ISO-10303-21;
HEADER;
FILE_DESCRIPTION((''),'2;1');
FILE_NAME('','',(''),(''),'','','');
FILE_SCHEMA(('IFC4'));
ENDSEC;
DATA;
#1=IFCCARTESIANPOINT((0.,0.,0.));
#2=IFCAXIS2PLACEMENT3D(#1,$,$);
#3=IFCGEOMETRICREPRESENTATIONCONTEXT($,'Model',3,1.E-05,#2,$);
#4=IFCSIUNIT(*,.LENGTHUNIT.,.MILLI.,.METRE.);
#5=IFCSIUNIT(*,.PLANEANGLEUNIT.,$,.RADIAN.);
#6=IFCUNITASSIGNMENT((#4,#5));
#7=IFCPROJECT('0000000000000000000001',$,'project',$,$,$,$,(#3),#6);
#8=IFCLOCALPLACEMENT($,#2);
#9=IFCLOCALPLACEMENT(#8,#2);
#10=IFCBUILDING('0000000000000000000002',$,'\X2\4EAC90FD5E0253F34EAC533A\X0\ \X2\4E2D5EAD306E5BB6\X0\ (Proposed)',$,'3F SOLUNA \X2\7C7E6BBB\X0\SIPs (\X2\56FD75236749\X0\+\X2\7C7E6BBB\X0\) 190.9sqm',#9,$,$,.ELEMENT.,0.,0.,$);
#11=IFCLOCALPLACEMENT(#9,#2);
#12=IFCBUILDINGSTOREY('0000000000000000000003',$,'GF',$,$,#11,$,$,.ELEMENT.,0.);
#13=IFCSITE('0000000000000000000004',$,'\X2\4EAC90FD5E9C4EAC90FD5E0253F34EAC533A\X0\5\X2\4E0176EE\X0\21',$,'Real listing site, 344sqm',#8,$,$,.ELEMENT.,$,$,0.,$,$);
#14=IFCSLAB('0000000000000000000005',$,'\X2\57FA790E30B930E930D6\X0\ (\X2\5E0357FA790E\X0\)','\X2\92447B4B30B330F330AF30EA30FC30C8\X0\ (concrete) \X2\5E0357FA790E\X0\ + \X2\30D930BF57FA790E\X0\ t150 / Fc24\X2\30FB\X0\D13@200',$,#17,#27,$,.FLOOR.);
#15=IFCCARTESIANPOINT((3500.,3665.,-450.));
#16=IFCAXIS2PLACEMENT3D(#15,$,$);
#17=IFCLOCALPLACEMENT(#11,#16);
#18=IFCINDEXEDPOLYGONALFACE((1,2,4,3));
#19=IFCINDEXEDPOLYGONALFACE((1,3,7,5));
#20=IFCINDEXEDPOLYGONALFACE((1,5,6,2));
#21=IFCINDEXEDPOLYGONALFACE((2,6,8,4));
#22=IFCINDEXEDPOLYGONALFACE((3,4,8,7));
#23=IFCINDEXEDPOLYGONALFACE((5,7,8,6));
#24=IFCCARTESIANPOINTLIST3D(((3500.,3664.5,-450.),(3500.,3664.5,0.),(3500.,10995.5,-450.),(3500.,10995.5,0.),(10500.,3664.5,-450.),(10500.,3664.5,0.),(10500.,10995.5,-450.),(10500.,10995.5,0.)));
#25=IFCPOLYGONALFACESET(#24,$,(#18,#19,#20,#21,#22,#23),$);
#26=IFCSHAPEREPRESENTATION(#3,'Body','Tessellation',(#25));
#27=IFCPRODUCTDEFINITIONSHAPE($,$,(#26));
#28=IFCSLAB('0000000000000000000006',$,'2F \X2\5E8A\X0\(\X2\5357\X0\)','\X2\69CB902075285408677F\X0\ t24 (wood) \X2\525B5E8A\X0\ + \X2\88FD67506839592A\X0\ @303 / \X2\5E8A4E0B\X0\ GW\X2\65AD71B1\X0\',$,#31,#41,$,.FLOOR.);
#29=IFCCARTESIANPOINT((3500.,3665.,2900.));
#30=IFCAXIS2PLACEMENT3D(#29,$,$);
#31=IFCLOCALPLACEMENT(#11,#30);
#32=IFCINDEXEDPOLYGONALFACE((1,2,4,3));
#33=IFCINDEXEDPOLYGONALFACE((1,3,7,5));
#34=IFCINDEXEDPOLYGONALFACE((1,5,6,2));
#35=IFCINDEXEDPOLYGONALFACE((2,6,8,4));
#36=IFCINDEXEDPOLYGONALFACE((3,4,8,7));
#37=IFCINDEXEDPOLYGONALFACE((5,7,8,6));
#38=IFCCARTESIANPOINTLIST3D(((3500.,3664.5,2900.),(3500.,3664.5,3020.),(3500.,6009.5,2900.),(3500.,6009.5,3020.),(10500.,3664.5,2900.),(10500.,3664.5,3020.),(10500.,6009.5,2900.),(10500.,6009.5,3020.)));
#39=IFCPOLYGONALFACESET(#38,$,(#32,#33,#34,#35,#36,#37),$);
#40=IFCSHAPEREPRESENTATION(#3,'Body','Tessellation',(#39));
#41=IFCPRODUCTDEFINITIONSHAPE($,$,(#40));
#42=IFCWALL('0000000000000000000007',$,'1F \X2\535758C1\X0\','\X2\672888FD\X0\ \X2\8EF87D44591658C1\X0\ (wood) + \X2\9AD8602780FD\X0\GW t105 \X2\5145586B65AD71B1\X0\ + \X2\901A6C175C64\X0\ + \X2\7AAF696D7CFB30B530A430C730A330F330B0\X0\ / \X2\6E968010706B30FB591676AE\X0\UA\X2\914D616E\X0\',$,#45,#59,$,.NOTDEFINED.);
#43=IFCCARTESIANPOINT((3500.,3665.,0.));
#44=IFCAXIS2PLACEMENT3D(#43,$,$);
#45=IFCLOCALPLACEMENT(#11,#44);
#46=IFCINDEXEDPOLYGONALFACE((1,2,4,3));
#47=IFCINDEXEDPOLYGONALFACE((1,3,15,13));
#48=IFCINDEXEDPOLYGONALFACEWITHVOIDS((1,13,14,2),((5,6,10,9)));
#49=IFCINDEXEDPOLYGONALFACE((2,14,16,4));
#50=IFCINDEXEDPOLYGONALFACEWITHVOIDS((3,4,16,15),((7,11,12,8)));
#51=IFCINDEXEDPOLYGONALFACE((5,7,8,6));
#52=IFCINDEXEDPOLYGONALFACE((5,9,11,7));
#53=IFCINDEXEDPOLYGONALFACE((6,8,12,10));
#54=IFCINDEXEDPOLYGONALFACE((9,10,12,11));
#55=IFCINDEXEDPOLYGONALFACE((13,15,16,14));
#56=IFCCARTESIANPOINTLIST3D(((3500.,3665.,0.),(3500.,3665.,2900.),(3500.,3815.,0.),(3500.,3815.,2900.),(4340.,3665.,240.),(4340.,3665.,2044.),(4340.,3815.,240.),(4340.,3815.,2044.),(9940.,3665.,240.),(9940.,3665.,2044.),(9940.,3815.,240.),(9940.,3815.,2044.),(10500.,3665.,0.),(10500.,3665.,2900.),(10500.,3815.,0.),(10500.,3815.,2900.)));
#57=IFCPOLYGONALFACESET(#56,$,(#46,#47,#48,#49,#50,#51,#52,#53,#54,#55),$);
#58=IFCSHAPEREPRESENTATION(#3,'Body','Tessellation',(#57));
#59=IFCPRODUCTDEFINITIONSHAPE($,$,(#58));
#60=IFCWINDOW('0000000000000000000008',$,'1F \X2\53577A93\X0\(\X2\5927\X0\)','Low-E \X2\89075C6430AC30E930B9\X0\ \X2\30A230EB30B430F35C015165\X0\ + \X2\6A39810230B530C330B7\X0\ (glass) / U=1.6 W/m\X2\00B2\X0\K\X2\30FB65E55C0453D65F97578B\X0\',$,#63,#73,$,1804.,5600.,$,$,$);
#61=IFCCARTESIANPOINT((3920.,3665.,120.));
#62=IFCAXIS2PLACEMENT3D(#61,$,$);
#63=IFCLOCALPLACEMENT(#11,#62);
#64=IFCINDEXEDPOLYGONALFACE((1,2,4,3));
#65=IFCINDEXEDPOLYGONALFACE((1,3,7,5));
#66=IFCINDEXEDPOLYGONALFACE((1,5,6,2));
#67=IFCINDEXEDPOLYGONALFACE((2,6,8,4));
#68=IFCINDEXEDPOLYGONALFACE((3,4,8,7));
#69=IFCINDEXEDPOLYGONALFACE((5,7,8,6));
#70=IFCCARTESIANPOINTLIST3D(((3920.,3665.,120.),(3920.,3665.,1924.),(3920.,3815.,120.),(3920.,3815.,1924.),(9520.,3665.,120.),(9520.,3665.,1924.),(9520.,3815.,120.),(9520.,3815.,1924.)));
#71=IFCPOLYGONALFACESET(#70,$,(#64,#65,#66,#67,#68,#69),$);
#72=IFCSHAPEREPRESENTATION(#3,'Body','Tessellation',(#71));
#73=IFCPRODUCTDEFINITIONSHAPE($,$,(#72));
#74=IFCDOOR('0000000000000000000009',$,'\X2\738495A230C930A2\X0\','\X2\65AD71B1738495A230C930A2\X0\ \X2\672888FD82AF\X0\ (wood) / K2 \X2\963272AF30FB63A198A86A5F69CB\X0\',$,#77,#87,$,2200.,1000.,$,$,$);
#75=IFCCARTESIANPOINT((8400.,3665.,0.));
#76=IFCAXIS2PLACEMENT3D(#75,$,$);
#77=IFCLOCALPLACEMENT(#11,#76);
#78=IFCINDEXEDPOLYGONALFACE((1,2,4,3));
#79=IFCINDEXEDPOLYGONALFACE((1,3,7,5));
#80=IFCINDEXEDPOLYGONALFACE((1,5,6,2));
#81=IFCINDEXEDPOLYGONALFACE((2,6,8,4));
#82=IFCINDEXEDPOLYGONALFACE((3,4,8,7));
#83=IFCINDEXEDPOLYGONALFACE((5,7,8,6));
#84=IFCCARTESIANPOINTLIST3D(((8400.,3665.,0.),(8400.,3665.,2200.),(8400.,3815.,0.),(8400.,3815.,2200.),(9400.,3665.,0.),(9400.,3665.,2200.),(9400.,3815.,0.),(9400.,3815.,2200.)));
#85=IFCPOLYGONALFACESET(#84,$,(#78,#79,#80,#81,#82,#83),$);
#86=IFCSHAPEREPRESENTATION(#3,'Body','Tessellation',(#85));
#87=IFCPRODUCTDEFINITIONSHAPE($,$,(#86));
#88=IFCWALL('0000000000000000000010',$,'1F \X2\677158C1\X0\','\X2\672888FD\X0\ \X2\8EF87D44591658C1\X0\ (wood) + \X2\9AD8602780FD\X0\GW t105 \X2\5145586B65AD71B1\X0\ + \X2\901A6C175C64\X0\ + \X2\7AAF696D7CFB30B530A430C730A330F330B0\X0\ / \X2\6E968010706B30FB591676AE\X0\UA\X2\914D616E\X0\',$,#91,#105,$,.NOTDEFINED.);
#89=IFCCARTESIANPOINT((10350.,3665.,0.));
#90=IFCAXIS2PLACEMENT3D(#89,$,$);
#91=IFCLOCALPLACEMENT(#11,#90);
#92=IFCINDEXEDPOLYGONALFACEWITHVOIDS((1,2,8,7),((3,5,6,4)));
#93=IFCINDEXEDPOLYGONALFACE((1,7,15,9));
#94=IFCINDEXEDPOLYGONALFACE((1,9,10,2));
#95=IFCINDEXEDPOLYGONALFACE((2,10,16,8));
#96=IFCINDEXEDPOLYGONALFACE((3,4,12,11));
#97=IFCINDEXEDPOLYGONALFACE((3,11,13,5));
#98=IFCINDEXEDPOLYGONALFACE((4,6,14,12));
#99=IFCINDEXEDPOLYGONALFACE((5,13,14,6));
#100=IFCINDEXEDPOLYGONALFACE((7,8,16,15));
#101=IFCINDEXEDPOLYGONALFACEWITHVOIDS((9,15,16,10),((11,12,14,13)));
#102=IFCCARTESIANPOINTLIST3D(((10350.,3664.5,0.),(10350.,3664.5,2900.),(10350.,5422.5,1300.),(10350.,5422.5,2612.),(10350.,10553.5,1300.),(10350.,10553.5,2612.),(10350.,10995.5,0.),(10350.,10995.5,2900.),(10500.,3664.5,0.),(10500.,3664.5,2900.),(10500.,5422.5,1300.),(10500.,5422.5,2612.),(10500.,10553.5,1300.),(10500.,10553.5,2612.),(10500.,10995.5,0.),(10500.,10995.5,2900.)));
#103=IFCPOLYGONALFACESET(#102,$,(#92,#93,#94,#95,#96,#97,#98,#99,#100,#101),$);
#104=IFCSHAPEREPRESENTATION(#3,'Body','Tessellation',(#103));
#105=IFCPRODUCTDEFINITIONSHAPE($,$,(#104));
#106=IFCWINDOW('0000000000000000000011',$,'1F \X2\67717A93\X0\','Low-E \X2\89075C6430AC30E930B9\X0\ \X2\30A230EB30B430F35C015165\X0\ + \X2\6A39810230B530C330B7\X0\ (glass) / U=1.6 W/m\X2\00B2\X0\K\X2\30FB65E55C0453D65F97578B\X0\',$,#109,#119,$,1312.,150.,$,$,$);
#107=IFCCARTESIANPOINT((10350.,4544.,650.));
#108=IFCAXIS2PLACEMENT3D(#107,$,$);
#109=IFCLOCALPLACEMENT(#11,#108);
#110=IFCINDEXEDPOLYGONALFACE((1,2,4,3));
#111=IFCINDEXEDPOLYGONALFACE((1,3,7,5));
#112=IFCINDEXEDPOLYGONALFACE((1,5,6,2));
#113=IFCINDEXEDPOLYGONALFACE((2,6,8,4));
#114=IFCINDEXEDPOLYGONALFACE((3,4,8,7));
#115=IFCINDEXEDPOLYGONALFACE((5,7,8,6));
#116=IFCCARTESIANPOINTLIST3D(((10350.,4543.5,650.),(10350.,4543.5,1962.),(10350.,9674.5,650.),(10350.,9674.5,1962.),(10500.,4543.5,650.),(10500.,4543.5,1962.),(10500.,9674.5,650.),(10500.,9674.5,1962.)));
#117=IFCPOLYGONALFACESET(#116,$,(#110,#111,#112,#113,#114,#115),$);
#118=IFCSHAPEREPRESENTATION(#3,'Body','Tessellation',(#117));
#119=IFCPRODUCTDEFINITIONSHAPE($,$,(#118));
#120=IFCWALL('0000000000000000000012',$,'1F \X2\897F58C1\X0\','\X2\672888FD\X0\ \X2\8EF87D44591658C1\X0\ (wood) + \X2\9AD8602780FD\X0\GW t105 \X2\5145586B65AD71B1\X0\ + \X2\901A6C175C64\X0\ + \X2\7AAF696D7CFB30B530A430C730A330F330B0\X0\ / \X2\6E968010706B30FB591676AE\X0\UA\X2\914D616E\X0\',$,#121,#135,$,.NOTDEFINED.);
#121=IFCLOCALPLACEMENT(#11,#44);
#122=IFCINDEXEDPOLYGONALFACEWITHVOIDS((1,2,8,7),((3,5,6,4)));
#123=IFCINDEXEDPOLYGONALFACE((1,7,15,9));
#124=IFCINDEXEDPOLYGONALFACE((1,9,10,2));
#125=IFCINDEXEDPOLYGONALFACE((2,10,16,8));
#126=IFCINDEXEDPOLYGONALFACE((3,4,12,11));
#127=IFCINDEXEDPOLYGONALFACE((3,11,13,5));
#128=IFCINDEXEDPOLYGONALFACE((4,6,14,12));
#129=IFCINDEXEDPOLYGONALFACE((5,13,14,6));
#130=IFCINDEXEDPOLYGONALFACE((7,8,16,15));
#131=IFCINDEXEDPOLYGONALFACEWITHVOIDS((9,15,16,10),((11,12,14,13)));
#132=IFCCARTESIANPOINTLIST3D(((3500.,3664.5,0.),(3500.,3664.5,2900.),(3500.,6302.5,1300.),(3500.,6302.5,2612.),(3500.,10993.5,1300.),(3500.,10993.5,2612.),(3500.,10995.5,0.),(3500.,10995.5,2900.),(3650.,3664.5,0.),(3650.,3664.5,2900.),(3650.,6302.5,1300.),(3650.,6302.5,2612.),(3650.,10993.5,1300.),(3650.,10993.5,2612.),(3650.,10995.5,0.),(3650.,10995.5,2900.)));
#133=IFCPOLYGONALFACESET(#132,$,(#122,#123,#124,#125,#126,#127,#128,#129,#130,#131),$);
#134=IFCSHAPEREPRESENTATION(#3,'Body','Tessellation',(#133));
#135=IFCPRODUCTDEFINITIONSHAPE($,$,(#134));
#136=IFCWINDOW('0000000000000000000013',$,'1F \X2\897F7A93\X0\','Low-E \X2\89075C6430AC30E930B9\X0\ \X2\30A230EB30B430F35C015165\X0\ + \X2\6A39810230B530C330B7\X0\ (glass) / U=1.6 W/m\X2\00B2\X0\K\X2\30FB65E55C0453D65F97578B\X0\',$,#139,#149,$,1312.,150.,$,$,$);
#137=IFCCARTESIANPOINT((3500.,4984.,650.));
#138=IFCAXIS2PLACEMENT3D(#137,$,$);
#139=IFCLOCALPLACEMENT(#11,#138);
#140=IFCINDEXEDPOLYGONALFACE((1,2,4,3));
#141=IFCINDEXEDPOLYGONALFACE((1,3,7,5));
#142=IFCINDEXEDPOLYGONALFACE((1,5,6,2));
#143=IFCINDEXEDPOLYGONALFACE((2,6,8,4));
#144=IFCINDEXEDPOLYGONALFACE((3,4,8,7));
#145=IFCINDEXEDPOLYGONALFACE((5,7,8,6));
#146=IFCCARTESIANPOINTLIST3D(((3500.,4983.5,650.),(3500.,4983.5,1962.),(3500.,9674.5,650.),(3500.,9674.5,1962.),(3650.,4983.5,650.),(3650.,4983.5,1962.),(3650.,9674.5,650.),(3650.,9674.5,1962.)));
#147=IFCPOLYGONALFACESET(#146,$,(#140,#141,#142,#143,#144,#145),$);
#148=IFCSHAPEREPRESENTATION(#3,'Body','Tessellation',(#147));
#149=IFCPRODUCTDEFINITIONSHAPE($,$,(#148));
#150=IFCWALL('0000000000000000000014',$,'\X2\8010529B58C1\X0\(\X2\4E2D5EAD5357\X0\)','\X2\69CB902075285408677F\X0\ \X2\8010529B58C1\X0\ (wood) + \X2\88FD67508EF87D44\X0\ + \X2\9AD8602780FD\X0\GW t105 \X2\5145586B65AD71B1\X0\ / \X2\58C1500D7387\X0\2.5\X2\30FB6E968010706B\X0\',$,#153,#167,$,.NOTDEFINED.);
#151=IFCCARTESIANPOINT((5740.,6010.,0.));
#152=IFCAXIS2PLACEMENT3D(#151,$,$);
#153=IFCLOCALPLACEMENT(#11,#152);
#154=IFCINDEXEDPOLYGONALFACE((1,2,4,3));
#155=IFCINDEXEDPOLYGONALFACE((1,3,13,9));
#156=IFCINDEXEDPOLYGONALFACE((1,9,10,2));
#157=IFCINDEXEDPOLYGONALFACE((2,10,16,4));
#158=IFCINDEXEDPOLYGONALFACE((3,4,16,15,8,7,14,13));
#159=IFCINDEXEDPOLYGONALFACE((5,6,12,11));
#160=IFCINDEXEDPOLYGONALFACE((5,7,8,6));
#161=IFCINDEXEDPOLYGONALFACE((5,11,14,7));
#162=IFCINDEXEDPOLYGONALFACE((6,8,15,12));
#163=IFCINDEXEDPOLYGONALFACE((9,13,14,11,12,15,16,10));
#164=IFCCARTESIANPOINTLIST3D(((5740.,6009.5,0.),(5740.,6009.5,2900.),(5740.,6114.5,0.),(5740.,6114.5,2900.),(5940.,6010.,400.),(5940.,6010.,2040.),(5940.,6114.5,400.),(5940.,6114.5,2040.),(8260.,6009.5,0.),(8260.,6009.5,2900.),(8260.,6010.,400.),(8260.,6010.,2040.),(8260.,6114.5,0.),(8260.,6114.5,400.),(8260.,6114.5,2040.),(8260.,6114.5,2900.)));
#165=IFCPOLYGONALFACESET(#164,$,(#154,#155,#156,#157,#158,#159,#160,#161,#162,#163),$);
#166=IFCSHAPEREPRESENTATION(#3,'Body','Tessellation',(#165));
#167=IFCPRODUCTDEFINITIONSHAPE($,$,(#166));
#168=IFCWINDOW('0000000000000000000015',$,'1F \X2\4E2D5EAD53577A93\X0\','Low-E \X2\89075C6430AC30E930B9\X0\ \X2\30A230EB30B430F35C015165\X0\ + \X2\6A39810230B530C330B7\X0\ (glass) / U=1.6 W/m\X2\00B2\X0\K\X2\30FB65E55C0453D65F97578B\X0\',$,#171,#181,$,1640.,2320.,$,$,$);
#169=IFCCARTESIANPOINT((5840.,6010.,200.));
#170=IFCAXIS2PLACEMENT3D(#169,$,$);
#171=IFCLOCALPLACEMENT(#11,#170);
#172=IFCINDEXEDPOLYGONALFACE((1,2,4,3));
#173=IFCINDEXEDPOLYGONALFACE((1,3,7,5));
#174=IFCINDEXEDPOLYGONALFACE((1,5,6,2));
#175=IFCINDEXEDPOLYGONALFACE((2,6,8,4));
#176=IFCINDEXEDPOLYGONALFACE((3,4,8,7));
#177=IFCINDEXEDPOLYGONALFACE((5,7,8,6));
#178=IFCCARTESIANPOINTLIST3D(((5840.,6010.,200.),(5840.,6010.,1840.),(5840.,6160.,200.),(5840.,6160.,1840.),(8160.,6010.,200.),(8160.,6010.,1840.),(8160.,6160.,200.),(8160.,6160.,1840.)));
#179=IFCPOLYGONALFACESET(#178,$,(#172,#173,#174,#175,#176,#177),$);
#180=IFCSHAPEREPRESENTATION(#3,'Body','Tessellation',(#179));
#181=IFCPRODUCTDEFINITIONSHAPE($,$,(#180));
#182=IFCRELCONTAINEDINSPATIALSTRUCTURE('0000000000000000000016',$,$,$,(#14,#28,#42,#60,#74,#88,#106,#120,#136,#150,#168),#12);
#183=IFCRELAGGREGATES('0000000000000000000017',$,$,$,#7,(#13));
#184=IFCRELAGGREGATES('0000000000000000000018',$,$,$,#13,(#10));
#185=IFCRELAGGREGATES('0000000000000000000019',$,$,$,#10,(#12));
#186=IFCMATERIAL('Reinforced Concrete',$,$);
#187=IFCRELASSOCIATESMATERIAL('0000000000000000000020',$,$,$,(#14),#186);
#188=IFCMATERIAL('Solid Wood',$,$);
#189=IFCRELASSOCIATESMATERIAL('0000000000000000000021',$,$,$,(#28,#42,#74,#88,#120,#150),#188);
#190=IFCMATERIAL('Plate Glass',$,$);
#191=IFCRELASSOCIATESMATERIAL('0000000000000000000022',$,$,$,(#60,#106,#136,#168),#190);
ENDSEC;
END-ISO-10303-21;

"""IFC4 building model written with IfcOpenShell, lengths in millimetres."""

from ifc_helpers import new_model, si_unit, frame, frame_2d, origin, place, context, project, spatial, rectangle, extrude, material, element, fill, save


model = new_model("IFC4")

# Units and contexts
model_context = context("Model", 3, precision=1e-05, world=origin())
ifc_project = project(units=[si_unit("LENGTHUNIT", "METRE", prefix="MILLI"), si_unit("PLANEANGLEUNIT", "RADIAN")], contexts=[model_context])

# Site, building, storey
site_placement = place(None, origin())
site = spatial("IfcSite", under=ifc_project, at=site_placement, Name="京都府京都市右京区5丁目21", ObjectType="Real listing site, 344sqm", CompositionType="ELEMENT", RefElevation=0.0)
building_placement = place(site_placement, origin())
building = spatial("IfcBuilding", under=site, at=building_placement, Name="京都市右京区 中庭の家 (Proposed)", ObjectType="3F SOLUNA 籾殻SIPs (国産杉+籾殻) 190.9sqm", CompositionType="ELEMENT", ElevationOfRefHeight=0.0, ElevationOfTerrain=0.0)
storey_placement = place(building_placement, origin())
storey = spatial("IfcBuildingStorey", under=building, at=storey_placement, Name="GF", CompositionType="ELEMENT", Elevation=0.0)

# Slabs
ifc_material_1 = material(Name="Reinforced Concrete")
slab_1_placement = place(storey_placement, frame((3500.0, 3665.0, -450.0)))
element("IfcSlab", 1, at=slab_1_placement, inside=storey, material=ifc_material_1, Name="基礎スラブ (布基礎)", Description="鉄筋コンクリート (concrete) 布基礎 + ベタ基礎 t150 / Fc24・D13@200", PredefinedType="FLOOR", context=model_context, shape_type="SweptSolid", body=[
    extrude(rectangle(XDim=7000.0, YDim=7331.0, at=frame_2d((3500.0, 3665.0))), frame((3500.0, 3665.0, -450.0)), (0.0, 0.0, 1.0), 450.0),
])
ifc_material_2 = material(Name="Solid Wood")
slab_2_placement = place(storey_placement, frame((3500.0, 3665.0, 2900.0)))
element("IfcSlab", 2, at=slab_2_placement, inside=storey, material=ifc_material_2, Name="2F 床(南)", Description="構造用合板 t24 (wood) 剛床 + 製材根太 @303 / 床下 GW断熱", PredefinedType="FLOOR", context=model_context, shape_type="SweptSolid", body=[
    extrude(rectangle(XDim=7000.0, YDim=2345.0, at=frame_2d((3500.0, 1172.0))), frame((3500.0, 3665.0, 2900.0)), (0.0, 0.0, 1.0), 120.0),
])

# Wall, openings, window, door
wall_1_placement = place(storey_placement, frame((3500.0, 3665.0, 0.0)))
wall_1 = element("IfcWall", 3, at=wall_1_placement, inside=storey, material=ifc_material_2, Name="1F 南壁", Description="木製 軸組外壁 (wood) + 高性能GW t105 充填断熱 + 通気層 + 窯業系サイディング / 準耐火・外皮UA配慮", PredefinedType="NOTDEFINED", context=model_context, shape_type="SweptSolid", body=[
    extrude(rectangle(XDim=7000.0, YDim=150.0, at=frame_2d((3500.0, 75.0))), frame((3500.0, 3665.0, 0.0)), (0.0, 0.0, 1.0), 2900.0),
])
opening_1_placement = place(storey_placement, frame((3920.0, 3665.0, 120.0)))
opening_1 = element("IfcOpeningElement", 4, at=opening_1_placement, cuts=wall_1, PredefinedType="NOTDEFINED", context=model_context, shape_type="SweptSolid", body=[
    extrude(rectangle(XDim=5600.0, YDim=150.0, at=frame_2d((2800.0, 75.0))), frame((3920.0, 3665.0, 120.0)), (0.0, 0.0, 1.0), 1804.0),
])
opening_2_placement = place(storey_placement, frame((8400.0, 3665.0, 0.0)))
opening_2 = element("IfcOpeningElement", 5, at=opening_2_placement, cuts=wall_1, PredefinedType="NOTDEFINED", context=model_context, shape_type="SweptSolid", body=[
    extrude(rectangle(XDim=1000.0, YDim=150.0, at=frame_2d((500.0, 75.0))), frame((8400.0, 3665.0, 0.0)), (0.0, 0.0, 1.0), 2200.0),
])
ifc_material_3 = material(Name="Plate Glass")
window_1_placement = place(storey_placement, frame((3920.0, 3665.0, 120.0)))
window_1 = element("IfcWindow", 6, at=window_1_placement, inside=storey, material=ifc_material_3, Name="1F 南窓(大)", Description="Low-E 複層ガラス アルゴン封入 + 樹脂サッシ (glass) / U=1.6 W/m²K・日射取得型", OverallHeight=1804.0, OverallWidth=5600.0, context=model_context, shape_type="SweptSolid", body=[
    extrude(rectangle(XDim=5600.0, YDim=150.0, at=frame_2d((2800.0, 75.0))), frame((3920.0, 3665.0, 120.0)), (0.0, 0.0, 1.0), 1804.0),
])
fill(opening_1, window_1)
door_placement = place(storey_placement, frame((8400.0, 3665.0, 0.0)))
door = element("IfcDoor", 7, at=door_placement, inside=storey, material=ifc_material_2, Name="玄関ドア", Description="断熱玄関ドア 木製芯 (wood) / K2 防犯・採風機構", OverallHeight=2200.0, OverallWidth=1000.0, context=model_context, shape_type="SweptSolid", body=[
    extrude(rectangle(XDim=1000.0, YDim=150.0, at=frame_2d((500.0, 75.0))), frame((8400.0, 3665.0, 0.0)), (0.0, 0.0, 1.0), 2200.0),
])
fill(opening_2, door)

# Walls, openings, windows
wall_2_placement = place(storey_placement, frame((10350.0, 3665.0, 0.0)))
wall_2 = element("IfcWall", 8, at=wall_2_placement, inside=storey, material=ifc_material_2, Name="1F 東壁", Description="木製 軸組外壁 (wood) + 高性能GW t105 充填断熱 + 通気層 + 窯業系サイディング / 準耐火・外皮UA配慮", PredefinedType="NOTDEFINED", context=model_context, shape_type="SweptSolid", body=[
    extrude(rectangle(XDim=150.0, YDim=7331.0, at=frame_2d((75.0, 3665.0))), frame((10350.0, 3665.0, 0.0)), (0.0, 0.0, 1.0), 2900.0),
])
opening_3_placement = place(storey_placement, frame((10350.0, 4544.0, 650.0)))
opening_3 = element("IfcOpeningElement", 9, at=opening_3_placement, cuts=wall_2, PredefinedType="NOTDEFINED", context=model_context, shape_type="SweptSolid", body=[
    extrude(rectangle(XDim=150.0, YDim=5131.0, at=frame_2d((75.0, 2565.0))), frame((10350.0, 4544.0, 650.0)), (0.0, 0.0, 1.0), 1312.0),
])
window_2_placement = place(storey_placement, frame((10350.0, 4544.0, 650.0)))
window_2 = element("IfcWindow", 10, at=window_2_placement, inside=storey, material=ifc_material_3, Name="1F 東窓", Description="Low-E 複層ガラス アルゴン封入 + 樹脂サッシ (glass) / U=1.6 W/m²K・日射取得型", OverallHeight=1312.0, OverallWidth=150.0, context=model_context, shape_type="SweptSolid", body=[
    extrude(rectangle(XDim=150.0, YDim=5131.0, at=frame_2d((75.0, 2565.0))), frame((10350.0, 4544.0, 650.0)), (0.0, 0.0, 1.0), 1312.0),
])
fill(opening_3, window_2)
wall_3_placement = place(storey_placement, frame((3500.0, 3665.0, 0.0)))
wall_3 = element("IfcWall", 11, at=wall_3_placement, inside=storey, material=ifc_material_2, Name="1F 西壁", Description="木製 軸組外壁 (wood) + 高性能GW t105 充填断熱 + 通気層 + 窯業系サイディング / 準耐火・外皮UA配慮", PredefinedType="NOTDEFINED", context=model_context, shape_type="SweptSolid", body=[
    extrude(rectangle(XDim=150.0, YDim=7331.0, at=frame_2d((75.0, 3665.0))), frame((3500.0, 3665.0, 0.0)), (0.0, 0.0, 1.0), 2900.0),
])
opening_4_placement = place(storey_placement, frame((3500.0, 4984.0, 650.0)))
opening_4 = element("IfcOpeningElement", 12, at=opening_4_placement, cuts=wall_3, PredefinedType="NOTDEFINED", context=model_context, shape_type="SweptSolid", body=[
    extrude(rectangle(XDim=150.0, YDim=4691.0, at=frame_2d((75.0, 2345.0))), frame((3500.0, 4984.0, 650.0)), (0.0, 0.0, 1.0), 1312.0),
])
window_3_placement = place(storey_placement, frame((3500.0, 4984.0, 650.0)))
window_3 = element("IfcWindow", 13, at=window_3_placement, inside=storey, material=ifc_material_3, Name="1F 西窓", Description="Low-E 複層ガラス アルゴン封入 + 樹脂サッシ (glass) / U=1.6 W/m²K・日射取得型", OverallHeight=1312.0, OverallWidth=150.0, context=model_context, shape_type="SweptSolid", body=[
    extrude(rectangle(XDim=150.0, YDim=4691.0, at=frame_2d((75.0, 2345.0))), frame((3500.0, 4984.0, 650.0)), (0.0, 0.0, 1.0), 1312.0),
])
fill(opening_4, window_3)
wall_4_placement = place(storey_placement, frame((5740.0, 6010.0, 0.0)))
wall_4 = element("IfcWall", 14, at=wall_4_placement, inside=storey, material=ifc_material_2, Name="耐力壁(中庭南)", Description="構造用合板 耐力壁 (wood) + 製材軸組 + 高性能GW t105 充填断熱 / 壁倍率2.5・準耐火", PredefinedType="NOTDEFINED", context=model_context, shape_type="SweptSolid", body=[
    extrude(rectangle(XDim=2520.0, YDim=105.0, at=frame_2d((1260.0, 52.0))), frame((5740.0, 6010.0, 0.0)), (0.0, 0.0, 1.0), 2900.0),
])
opening_5_placement = place(storey_placement, frame((5840.0, 6010.0, 200.0)))
opening_5 = element("IfcOpeningElement", 15, at=opening_5_placement, cuts=wall_4, PredefinedType="NOTDEFINED", context=model_context, shape_type="SweptSolid", body=[
    extrude(rectangle(XDim=2320.0, YDim=150.0, at=frame_2d((1160.0, 75.0))), frame((5840.0, 6010.0, 200.0)), (0.0, 0.0, 1.0), 1640.0),
])
window_4_placement = place(storey_placement, frame((5840.0, 6010.0, 200.0)))
window_4 = element("IfcWindow", 16, at=window_4_placement, inside=storey, material=ifc_material_3, Name="1F 中庭南窓", Description="Low-E 複層ガラス アルゴン封入 + 樹脂サッシ (glass) / U=1.6 W/m²K・日射取得型", OverallHeight=1640.0, OverallWidth=2320.0, context=model_context, shape_type="SweptSolid", body=[
    extrude(rectangle(XDim=2320.0, YDim=150.0, at=frame_2d((1160.0, 75.0))), frame((5840.0, 6010.0, 200.0)), (0.0, 0.0, 1.0), 1640.0),
])
fill(opening_5, window_4)

save(model, "model.ifc")
